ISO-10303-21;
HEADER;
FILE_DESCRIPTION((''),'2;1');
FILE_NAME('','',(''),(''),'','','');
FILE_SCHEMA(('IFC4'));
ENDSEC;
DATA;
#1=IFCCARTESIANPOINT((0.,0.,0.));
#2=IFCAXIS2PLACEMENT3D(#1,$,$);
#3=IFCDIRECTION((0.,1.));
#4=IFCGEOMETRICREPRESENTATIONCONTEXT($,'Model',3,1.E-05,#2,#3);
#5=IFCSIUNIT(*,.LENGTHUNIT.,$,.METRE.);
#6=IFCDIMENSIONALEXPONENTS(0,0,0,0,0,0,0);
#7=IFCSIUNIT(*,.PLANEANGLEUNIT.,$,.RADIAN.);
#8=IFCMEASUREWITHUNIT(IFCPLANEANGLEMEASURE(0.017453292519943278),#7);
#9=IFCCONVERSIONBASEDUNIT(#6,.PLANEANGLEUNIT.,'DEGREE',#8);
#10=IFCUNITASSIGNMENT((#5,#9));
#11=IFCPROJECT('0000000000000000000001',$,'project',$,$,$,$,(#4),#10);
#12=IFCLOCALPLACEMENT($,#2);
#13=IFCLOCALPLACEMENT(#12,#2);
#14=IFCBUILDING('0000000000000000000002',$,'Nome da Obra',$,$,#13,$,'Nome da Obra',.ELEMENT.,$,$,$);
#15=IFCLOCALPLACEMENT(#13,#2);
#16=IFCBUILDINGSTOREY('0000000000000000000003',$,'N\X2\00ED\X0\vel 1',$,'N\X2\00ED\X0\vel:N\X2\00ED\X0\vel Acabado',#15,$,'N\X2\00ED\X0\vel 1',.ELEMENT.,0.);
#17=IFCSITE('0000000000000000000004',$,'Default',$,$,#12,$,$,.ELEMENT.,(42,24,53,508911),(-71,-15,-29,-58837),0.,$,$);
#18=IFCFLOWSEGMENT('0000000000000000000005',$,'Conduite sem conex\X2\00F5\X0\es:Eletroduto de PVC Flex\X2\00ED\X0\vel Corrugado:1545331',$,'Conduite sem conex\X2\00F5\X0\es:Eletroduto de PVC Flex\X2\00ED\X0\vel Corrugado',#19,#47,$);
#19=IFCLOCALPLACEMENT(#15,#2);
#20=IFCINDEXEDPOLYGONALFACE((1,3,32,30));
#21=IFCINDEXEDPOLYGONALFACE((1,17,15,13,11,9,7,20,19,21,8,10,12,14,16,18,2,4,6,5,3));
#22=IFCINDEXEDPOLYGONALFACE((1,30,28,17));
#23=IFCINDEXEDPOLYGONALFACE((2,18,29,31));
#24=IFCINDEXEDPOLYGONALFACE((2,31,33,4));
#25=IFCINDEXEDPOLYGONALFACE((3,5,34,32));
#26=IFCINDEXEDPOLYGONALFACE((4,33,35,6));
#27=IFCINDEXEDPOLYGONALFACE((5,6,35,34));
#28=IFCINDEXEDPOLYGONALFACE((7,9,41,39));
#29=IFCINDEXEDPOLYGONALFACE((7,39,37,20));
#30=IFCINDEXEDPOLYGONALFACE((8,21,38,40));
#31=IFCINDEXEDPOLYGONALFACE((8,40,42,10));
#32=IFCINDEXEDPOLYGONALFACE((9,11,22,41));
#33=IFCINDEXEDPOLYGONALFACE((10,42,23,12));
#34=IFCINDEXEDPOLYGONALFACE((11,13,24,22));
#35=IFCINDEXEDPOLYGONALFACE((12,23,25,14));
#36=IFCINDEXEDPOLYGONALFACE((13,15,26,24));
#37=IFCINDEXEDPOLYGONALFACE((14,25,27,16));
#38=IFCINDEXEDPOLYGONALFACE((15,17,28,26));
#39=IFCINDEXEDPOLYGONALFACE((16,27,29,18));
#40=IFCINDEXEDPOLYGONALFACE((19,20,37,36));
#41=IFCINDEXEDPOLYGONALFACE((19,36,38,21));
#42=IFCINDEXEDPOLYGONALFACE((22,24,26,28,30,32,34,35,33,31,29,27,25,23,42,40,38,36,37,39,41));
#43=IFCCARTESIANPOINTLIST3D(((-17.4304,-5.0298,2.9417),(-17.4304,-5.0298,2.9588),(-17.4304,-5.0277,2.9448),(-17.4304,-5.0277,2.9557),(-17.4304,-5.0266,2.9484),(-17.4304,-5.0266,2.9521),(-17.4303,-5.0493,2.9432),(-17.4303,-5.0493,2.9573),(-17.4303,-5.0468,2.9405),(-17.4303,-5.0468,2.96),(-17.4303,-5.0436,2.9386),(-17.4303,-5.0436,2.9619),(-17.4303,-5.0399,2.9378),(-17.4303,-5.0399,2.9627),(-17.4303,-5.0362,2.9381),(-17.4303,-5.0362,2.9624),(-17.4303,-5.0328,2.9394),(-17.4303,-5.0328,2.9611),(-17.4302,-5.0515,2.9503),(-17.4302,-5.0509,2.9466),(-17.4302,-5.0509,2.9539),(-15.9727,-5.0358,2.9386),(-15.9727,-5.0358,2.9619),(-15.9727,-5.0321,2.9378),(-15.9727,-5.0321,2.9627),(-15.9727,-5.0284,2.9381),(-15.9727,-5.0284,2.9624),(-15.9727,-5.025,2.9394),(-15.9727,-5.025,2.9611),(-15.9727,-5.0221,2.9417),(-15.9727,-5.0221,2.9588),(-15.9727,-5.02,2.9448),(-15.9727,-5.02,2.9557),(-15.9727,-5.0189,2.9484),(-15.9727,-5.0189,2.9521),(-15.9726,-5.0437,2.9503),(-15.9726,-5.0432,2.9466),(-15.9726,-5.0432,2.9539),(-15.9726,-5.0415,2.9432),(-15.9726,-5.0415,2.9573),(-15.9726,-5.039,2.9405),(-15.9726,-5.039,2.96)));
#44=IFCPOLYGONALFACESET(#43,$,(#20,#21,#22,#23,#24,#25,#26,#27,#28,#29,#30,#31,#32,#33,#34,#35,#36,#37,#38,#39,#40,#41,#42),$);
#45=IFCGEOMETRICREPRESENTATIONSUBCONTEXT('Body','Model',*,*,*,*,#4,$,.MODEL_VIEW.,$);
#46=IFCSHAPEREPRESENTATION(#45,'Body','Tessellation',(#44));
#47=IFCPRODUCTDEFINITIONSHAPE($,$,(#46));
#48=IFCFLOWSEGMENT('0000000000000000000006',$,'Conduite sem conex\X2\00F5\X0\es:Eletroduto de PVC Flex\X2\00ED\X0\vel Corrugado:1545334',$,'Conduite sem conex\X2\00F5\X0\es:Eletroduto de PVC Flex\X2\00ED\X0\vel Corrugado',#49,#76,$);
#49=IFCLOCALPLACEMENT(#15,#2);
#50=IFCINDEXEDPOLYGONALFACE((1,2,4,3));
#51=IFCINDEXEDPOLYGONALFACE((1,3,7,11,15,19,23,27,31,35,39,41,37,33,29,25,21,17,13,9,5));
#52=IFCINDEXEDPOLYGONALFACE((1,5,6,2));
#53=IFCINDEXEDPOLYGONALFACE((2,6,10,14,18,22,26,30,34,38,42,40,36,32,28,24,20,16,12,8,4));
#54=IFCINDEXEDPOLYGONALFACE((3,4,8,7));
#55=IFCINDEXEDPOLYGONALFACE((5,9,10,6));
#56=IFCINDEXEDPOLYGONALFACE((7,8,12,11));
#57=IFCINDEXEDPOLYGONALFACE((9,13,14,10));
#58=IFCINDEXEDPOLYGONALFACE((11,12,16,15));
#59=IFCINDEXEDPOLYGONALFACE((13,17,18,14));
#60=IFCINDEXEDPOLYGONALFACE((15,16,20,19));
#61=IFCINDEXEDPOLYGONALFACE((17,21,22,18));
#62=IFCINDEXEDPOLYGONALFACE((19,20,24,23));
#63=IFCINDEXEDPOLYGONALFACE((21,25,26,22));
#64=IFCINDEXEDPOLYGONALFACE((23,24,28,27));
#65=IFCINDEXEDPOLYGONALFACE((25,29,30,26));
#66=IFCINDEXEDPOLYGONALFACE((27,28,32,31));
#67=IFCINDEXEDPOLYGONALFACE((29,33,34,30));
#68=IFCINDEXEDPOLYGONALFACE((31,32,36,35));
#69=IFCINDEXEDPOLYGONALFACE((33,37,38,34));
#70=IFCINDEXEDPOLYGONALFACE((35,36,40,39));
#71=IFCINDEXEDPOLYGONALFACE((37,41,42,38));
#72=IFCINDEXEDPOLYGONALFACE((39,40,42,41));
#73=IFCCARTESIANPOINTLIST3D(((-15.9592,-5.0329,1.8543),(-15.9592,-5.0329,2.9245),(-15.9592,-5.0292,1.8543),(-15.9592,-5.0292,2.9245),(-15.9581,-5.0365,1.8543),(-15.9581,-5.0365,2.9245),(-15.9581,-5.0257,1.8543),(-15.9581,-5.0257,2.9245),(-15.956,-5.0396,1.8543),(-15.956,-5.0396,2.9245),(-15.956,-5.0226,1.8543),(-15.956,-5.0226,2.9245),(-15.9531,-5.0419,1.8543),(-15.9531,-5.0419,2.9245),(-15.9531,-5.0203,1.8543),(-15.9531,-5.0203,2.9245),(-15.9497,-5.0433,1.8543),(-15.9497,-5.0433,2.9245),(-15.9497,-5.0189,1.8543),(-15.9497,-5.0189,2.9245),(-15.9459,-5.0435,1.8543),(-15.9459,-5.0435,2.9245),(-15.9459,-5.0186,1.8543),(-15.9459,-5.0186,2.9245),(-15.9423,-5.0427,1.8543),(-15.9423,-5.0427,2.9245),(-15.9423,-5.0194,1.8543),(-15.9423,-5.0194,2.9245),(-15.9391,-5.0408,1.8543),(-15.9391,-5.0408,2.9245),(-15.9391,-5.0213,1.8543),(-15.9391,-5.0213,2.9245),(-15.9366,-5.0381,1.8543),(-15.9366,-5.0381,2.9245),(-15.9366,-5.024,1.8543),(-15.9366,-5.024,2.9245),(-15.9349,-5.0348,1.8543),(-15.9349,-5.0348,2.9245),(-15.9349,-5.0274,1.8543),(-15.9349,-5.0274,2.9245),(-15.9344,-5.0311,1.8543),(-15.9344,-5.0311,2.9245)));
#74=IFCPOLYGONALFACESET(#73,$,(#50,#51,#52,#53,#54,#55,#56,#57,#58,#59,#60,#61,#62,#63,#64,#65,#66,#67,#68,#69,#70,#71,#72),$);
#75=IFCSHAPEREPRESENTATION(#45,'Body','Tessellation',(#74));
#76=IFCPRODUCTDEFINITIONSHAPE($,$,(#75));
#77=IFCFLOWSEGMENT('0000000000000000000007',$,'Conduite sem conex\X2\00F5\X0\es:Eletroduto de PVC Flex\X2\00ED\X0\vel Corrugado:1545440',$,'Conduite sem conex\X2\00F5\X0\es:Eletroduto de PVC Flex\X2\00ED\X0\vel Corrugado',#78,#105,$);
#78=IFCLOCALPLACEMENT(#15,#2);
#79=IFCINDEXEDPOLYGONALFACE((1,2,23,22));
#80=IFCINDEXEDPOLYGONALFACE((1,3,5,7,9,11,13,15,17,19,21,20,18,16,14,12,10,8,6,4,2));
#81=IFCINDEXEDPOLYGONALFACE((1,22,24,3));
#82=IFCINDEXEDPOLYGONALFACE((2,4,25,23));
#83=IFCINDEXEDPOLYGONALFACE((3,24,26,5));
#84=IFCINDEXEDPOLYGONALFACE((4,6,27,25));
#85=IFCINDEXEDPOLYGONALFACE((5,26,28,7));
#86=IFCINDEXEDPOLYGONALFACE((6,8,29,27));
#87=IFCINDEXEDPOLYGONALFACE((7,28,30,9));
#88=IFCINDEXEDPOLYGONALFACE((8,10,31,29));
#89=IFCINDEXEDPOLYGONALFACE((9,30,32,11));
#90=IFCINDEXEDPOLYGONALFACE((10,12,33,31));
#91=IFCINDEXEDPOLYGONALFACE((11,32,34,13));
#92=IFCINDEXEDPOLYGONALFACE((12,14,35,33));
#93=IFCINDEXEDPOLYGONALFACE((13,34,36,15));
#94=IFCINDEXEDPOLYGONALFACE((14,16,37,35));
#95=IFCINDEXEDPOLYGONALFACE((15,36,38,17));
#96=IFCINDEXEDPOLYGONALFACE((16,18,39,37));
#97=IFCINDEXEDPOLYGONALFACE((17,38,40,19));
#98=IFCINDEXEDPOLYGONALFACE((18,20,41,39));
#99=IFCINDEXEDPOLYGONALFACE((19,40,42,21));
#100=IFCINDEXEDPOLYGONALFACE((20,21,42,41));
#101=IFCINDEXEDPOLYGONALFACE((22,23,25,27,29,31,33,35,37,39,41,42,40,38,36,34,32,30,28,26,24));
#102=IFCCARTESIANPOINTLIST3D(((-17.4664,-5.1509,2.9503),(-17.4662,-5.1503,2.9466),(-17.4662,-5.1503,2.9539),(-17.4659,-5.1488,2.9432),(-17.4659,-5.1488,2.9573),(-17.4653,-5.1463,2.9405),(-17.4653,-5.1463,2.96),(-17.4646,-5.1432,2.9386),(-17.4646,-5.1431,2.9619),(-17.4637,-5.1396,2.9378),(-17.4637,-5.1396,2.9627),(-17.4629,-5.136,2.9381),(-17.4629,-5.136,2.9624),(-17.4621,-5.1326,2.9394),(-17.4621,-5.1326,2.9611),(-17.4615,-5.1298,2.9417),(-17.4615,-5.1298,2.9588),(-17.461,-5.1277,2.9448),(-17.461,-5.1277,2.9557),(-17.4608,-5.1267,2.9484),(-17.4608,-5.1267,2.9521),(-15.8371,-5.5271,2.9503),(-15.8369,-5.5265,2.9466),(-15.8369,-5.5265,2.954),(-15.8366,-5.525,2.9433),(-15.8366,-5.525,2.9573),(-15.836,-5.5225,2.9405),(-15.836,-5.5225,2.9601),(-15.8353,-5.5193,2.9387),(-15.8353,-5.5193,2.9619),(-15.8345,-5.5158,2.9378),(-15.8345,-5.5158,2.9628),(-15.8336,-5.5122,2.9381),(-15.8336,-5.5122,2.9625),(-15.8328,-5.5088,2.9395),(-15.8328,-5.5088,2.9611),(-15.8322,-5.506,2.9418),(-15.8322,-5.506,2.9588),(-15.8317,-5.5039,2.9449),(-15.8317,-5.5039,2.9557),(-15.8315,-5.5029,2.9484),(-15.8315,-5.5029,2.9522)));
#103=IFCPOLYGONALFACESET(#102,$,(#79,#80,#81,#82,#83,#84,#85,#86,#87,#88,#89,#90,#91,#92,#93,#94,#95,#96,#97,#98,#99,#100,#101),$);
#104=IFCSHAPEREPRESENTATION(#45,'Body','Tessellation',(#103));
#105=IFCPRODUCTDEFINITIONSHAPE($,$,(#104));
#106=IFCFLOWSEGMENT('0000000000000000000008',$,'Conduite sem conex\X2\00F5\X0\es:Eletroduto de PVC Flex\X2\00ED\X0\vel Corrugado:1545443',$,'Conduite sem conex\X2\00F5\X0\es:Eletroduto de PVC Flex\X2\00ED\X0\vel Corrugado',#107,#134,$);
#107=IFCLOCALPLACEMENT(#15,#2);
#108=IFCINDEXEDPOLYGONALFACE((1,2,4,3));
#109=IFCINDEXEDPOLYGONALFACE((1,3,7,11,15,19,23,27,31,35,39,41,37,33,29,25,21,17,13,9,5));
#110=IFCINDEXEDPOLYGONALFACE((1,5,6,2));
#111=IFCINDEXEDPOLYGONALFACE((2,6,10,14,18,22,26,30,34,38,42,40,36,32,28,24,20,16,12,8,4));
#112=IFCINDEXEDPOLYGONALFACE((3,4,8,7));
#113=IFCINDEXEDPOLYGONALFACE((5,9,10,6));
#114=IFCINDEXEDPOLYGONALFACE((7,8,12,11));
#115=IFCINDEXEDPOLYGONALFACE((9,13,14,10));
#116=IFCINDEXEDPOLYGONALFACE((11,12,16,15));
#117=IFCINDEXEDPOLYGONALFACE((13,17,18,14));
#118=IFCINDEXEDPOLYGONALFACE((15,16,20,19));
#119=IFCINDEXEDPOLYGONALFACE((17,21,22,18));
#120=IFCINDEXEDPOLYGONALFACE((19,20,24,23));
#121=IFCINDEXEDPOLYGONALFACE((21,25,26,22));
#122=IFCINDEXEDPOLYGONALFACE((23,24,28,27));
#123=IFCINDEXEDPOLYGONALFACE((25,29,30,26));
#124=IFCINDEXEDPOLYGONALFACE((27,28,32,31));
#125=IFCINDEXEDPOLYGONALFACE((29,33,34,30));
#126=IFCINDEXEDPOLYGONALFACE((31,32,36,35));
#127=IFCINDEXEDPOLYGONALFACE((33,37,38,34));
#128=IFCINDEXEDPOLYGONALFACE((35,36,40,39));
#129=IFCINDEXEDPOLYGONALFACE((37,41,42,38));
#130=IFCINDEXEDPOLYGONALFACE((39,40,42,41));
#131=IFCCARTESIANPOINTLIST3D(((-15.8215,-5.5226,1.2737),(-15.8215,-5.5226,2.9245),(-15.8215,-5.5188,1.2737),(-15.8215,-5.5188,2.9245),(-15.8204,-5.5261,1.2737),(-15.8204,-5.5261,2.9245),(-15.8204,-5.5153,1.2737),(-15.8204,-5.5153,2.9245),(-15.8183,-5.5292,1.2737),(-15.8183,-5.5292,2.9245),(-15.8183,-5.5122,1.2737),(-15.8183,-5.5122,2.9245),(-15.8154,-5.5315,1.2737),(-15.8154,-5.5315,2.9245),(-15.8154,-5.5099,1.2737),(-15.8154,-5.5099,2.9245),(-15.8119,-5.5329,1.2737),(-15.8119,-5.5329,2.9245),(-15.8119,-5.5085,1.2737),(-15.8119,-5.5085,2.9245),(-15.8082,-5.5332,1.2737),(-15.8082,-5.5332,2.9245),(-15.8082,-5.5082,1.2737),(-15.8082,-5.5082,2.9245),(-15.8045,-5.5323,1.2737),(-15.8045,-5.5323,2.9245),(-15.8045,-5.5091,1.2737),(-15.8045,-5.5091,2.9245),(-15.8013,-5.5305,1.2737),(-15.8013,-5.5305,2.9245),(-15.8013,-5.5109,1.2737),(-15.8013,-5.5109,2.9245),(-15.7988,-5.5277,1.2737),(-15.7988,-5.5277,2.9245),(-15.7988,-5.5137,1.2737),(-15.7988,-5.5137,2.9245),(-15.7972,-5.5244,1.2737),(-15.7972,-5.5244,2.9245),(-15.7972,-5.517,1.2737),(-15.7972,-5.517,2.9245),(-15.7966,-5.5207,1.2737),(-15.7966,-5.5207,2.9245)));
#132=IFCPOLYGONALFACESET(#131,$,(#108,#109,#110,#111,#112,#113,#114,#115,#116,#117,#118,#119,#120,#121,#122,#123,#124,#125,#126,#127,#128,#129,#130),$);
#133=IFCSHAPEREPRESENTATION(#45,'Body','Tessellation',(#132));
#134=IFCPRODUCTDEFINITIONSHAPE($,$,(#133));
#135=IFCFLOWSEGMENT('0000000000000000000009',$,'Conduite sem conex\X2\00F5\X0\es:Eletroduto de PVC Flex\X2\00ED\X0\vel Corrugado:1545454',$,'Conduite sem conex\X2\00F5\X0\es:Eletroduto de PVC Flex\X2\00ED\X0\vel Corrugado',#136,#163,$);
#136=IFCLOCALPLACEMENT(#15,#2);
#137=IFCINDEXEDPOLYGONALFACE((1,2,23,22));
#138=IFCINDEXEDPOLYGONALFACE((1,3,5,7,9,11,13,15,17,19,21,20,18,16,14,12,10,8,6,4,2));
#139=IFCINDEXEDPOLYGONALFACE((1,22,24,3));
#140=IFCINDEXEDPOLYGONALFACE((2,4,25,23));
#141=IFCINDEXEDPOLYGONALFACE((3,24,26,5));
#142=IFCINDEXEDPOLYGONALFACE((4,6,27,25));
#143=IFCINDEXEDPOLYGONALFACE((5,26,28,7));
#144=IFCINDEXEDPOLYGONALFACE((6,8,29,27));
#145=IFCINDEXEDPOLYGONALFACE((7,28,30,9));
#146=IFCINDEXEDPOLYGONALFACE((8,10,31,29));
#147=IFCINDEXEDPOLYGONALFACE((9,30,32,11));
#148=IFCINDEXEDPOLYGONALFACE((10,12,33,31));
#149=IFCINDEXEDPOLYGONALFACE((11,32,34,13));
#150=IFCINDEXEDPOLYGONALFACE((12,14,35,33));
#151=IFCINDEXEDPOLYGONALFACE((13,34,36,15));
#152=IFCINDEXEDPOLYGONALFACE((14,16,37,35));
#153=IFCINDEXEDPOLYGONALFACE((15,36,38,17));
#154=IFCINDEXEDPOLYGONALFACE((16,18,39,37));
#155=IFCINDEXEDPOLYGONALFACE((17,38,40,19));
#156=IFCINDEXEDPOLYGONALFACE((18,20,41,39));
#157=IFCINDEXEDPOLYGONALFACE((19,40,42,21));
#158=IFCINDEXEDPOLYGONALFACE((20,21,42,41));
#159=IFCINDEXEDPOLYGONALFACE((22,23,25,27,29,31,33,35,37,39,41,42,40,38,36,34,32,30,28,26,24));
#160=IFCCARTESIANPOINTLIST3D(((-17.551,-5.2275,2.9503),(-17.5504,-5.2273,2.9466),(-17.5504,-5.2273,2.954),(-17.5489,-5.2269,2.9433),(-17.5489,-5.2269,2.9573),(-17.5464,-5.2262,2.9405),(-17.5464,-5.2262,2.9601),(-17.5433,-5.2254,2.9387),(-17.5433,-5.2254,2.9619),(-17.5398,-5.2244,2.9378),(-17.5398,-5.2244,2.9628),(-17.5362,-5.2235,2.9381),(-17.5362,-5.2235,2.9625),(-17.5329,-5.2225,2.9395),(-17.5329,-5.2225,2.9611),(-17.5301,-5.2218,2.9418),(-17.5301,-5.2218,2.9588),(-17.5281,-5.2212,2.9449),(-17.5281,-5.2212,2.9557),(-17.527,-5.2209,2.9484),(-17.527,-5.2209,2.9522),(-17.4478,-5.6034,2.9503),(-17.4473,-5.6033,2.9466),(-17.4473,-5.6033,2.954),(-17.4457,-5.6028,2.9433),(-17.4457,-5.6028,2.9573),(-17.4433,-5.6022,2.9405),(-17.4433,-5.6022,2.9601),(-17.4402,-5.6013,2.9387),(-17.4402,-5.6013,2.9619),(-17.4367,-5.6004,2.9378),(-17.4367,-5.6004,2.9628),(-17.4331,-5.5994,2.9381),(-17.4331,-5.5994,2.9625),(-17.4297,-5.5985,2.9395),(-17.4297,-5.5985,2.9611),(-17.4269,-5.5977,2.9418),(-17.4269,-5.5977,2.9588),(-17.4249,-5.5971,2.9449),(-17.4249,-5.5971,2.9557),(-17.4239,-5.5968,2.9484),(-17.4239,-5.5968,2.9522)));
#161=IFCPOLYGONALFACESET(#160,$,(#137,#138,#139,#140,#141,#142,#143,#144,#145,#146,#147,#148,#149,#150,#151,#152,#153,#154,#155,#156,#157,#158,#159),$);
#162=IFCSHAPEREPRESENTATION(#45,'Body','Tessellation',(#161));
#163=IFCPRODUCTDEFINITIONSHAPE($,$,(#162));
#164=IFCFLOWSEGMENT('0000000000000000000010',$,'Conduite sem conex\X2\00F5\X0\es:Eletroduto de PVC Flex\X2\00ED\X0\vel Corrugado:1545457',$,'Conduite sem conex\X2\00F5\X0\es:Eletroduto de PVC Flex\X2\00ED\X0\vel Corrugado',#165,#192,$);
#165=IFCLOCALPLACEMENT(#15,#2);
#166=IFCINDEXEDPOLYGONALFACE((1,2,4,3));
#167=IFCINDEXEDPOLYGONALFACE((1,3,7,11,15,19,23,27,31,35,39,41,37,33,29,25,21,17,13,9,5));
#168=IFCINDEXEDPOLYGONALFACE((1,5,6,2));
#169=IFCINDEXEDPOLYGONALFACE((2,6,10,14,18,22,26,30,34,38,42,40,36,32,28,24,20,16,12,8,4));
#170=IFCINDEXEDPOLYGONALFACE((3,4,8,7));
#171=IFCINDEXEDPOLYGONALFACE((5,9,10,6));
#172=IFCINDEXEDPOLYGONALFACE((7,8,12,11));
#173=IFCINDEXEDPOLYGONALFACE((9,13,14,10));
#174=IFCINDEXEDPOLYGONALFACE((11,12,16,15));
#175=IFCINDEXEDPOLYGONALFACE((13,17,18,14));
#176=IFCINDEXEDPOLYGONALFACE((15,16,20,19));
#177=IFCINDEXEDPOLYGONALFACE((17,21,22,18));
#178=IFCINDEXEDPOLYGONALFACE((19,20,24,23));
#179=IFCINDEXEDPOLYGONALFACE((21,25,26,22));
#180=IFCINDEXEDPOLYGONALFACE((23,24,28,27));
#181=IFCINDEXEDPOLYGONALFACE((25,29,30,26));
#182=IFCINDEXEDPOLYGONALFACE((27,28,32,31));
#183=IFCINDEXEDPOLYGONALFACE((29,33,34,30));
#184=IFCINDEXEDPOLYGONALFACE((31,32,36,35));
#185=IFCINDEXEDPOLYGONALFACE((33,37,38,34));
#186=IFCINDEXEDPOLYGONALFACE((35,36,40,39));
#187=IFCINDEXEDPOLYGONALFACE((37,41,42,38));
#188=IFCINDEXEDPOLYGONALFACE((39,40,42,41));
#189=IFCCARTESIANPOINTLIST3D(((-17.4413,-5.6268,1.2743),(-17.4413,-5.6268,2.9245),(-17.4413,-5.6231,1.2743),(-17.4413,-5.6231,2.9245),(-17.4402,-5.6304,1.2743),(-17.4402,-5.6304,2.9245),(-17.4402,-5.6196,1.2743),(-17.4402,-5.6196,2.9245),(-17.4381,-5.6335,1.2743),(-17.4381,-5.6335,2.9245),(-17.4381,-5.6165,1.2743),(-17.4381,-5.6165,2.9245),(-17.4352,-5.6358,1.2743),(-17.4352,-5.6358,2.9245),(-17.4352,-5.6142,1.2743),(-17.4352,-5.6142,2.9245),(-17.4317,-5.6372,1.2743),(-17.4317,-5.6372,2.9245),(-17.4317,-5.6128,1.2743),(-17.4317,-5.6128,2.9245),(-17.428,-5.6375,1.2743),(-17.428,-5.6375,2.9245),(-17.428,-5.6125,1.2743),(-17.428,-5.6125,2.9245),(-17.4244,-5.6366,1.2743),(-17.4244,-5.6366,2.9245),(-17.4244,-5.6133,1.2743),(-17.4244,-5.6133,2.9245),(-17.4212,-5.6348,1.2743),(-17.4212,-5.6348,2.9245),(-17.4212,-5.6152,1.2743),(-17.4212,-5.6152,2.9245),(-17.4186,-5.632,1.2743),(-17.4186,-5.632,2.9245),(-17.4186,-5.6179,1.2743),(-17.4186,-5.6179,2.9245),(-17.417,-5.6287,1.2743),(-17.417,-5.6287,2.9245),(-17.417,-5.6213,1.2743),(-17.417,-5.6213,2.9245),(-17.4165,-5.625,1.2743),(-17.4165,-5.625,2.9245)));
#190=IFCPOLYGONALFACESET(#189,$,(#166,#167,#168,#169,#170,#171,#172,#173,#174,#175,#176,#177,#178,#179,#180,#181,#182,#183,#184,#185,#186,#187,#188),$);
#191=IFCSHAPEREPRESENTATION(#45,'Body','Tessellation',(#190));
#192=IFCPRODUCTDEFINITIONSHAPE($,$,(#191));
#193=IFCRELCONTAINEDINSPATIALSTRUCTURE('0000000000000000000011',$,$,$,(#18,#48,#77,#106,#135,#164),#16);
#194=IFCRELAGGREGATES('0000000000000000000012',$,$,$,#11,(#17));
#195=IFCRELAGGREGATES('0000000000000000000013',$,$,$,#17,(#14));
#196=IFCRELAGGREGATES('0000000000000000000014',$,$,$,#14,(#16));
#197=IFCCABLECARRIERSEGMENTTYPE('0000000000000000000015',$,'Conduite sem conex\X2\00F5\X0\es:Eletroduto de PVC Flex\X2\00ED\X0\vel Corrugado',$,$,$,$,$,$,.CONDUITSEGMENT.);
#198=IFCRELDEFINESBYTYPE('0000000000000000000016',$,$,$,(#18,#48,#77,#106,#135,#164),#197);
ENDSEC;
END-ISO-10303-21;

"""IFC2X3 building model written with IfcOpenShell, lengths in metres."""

from ifc_helpers import new_model, entity, si_unit, converted_unit, direction, frame, frame_2d, origin, origin_2d_with_axis, place, context, subcontext, project, spatial, circle, extrude, type_object, element, save


model = new_model("IFC2X3")

# Units and contexts
model_context = context("Model", 3, precision=1e-05, world=origin(), true_north=direction((0.0, 1.0)))
body_context = subcontext(model_context, "Body", "Model", "MODEL_VIEW")
ifc_project = project(units=[si_unit("LENGTHUNIT", "METRE"), converted_unit("PLANEANGLEUNIT", "DEGREE", entity("IfcPlaneAngleMeasure", 0.017453292519943278), si_unit("PLANEANGLEUNIT", "RADIAN"), dimensions=[0, 0, 0, 0, 0, 0, 0])], contexts=[model_context])

# Site, building, storey
site_placement = place(None, origin())
site = spatial("IfcSite", under=ifc_project, at=site_placement, Name="Default", CompositionType="ELEMENT", RefLatitude=(42, 24, 53, 508911), RefLongitude=(-71, -15, -29, -58837), RefElevation=0.0)
building_placement = place(site_placement, origin())
building = spatial("IfcBuilding", under=site, at=building_placement, Name="Nome da Obra", LongName="Nome da Obra", CompositionType="ELEMENT")
storey_placement = place(building_placement, origin())
storey = spatial("IfcBuildingStorey", under=building, at=storey_placement, Name="Nível 1", ObjectType="Nível:Nível Acabado", LongName="Nível 1", CompositionType="ELEMENT", Elevation=0.0)

# Flow segments
cable_carrier_segment_type = type_object("IfcCableCarrierSegmentType", Name="Conduite sem conexões:Eletroduto de PVC Flexível Corrugado", PredefinedType="CONDUITSEGMENT")
flow_segment_1_placement = place(storey_placement, origin())
element("IfcFlowSegment", 1, at=flow_segment_1_placement, inside=storey, type_object=cable_carrier_segment_type, Name="Conduite sem conexões:Eletroduto de PVC Flexível Corrugado:1545331", ObjectType="Conduite sem conexões:Eletroduto de PVC Flexível Corrugado", context=body_context, shape_type="SweptSolid", body=[
    extrude(circle(Radius=0.0125, at=frame_2d((0.0, 0.0), x_axis=(1.0, 0.0))), frame((-17.4303, -5.039, 2.9503), z_axis=(0.999986, 0.005343, 0.0), x_axis=(0.005343, -0.999986, 0.0)), (0.0, 0.0, 1.0), 1.4576),
])
flow_segment_2_placement = place(storey_placement, origin())
element("IfcFlowSegment", 2, at=flow_segment_2_placement, inside=storey, type_object=cable_carrier_segment_type, Name="Conduite sem conexões:Eletroduto de PVC Flexível Corrugado:1545334", ObjectType="Conduite sem conexões:Eletroduto de PVC Flexível Corrugado", context=body_context, shape_type="SweptSolid", body=[
    extrude(circle(Radius=0.0125, at=frame_2d((0.0, 0.0), x_axis=(1.0, 0.0))), frame((-15.9469, -5.0311, 1.8543)), (0.0, 0.0, 1.0), 1.0702),
])
flow_segment_3_placement = place(storey_placement, origin())
element("IfcFlowSegment", 3, at=flow_segment_3_placement, inside=storey, type_object=cable_carrier_segment_type, Name="Conduite sem conexões:Eletroduto de PVC Flexível Corrugado:1545440", ObjectType="Conduite sem conexões:Eletroduto de PVC Flexível Corrugado", context=body_context, shape_type="SweptSolid", body=[
    extrude(circle(Radius=0.0125, at=frame_2d((0.0, 0.0), x_axis=(1.0, 0.0))), frame((-17.4635, -5.1387, 2.9503), z_axis=(0.974365, -0.224974, 0.00003), x_axis=(-0.224974, -0.974365, 0.0)), (0.0, 0.0, 1.0), 1.6722),
])
flow_segment_4_placement = place(storey_placement, origin())
element("IfcFlowSegment", 4, at=flow_segment_4_placement, inside=storey, type_object=cable_carrier_segment_type, Name="Conduite sem conexões:Eletroduto de PVC Flexível Corrugado:1545443", ObjectType="Conduite sem conexões:Eletroduto de PVC Flexível Corrugado", context=body_context, shape_type="SweptSolid", body=[
    extrude(circle(Radius=0.0125, at=frame_2d((0.0, 0.0), x_axis=(1.0, 0.0))), frame((-15.8091, -5.5207, 1.2737)), (0.0, 0.0, 1.0), 1.6508),
])
flow_segment_5_placement = place(storey_placement, origin())
element("IfcFlowSegment", 5, at=flow_segment_5_placement, inside=storey, type_object=cable_carrier_segment_type, Name="Conduite sem conexões:Eletroduto de PVC Flexível Corrugado:1545454", ObjectType="Conduite sem conexões:Eletroduto de PVC Flexível Corrugado", context=body_context, shape_type="SweptSolid", body=[
    extrude(circle(Radius=0.0125, at=origin_2d_with_axis()), frame((-17.4358, -5.6001, 2.9503), z_axis=(-0.264593, 0.96436, 0.0), x_axis=(-0.96436, -0.264593, 0.0)), (0.0, 0.0, 1.0), 0.3898),
])
flow_segment_6_placement = place(storey_placement, origin())
element("IfcFlowSegment", 6, at=flow_segment_6_placement, inside=storey, type_object=cable_carrier_segment_type, Name="Conduite sem conexões:Eletroduto de PVC Flexível Corrugado:1545457", ObjectType="Conduite sem conexões:Eletroduto de PVC Flexível Corrugado", context=body_context, shape_type="SweptSolid", body=[
    extrude(circle(Radius=0.0125, at=origin_2d_with_axis()), frame((-17.429, -5.625, 1.2743)), (0.0, 0.0, 1.0), 1.6502),
])

save(model, "model.ifc")
